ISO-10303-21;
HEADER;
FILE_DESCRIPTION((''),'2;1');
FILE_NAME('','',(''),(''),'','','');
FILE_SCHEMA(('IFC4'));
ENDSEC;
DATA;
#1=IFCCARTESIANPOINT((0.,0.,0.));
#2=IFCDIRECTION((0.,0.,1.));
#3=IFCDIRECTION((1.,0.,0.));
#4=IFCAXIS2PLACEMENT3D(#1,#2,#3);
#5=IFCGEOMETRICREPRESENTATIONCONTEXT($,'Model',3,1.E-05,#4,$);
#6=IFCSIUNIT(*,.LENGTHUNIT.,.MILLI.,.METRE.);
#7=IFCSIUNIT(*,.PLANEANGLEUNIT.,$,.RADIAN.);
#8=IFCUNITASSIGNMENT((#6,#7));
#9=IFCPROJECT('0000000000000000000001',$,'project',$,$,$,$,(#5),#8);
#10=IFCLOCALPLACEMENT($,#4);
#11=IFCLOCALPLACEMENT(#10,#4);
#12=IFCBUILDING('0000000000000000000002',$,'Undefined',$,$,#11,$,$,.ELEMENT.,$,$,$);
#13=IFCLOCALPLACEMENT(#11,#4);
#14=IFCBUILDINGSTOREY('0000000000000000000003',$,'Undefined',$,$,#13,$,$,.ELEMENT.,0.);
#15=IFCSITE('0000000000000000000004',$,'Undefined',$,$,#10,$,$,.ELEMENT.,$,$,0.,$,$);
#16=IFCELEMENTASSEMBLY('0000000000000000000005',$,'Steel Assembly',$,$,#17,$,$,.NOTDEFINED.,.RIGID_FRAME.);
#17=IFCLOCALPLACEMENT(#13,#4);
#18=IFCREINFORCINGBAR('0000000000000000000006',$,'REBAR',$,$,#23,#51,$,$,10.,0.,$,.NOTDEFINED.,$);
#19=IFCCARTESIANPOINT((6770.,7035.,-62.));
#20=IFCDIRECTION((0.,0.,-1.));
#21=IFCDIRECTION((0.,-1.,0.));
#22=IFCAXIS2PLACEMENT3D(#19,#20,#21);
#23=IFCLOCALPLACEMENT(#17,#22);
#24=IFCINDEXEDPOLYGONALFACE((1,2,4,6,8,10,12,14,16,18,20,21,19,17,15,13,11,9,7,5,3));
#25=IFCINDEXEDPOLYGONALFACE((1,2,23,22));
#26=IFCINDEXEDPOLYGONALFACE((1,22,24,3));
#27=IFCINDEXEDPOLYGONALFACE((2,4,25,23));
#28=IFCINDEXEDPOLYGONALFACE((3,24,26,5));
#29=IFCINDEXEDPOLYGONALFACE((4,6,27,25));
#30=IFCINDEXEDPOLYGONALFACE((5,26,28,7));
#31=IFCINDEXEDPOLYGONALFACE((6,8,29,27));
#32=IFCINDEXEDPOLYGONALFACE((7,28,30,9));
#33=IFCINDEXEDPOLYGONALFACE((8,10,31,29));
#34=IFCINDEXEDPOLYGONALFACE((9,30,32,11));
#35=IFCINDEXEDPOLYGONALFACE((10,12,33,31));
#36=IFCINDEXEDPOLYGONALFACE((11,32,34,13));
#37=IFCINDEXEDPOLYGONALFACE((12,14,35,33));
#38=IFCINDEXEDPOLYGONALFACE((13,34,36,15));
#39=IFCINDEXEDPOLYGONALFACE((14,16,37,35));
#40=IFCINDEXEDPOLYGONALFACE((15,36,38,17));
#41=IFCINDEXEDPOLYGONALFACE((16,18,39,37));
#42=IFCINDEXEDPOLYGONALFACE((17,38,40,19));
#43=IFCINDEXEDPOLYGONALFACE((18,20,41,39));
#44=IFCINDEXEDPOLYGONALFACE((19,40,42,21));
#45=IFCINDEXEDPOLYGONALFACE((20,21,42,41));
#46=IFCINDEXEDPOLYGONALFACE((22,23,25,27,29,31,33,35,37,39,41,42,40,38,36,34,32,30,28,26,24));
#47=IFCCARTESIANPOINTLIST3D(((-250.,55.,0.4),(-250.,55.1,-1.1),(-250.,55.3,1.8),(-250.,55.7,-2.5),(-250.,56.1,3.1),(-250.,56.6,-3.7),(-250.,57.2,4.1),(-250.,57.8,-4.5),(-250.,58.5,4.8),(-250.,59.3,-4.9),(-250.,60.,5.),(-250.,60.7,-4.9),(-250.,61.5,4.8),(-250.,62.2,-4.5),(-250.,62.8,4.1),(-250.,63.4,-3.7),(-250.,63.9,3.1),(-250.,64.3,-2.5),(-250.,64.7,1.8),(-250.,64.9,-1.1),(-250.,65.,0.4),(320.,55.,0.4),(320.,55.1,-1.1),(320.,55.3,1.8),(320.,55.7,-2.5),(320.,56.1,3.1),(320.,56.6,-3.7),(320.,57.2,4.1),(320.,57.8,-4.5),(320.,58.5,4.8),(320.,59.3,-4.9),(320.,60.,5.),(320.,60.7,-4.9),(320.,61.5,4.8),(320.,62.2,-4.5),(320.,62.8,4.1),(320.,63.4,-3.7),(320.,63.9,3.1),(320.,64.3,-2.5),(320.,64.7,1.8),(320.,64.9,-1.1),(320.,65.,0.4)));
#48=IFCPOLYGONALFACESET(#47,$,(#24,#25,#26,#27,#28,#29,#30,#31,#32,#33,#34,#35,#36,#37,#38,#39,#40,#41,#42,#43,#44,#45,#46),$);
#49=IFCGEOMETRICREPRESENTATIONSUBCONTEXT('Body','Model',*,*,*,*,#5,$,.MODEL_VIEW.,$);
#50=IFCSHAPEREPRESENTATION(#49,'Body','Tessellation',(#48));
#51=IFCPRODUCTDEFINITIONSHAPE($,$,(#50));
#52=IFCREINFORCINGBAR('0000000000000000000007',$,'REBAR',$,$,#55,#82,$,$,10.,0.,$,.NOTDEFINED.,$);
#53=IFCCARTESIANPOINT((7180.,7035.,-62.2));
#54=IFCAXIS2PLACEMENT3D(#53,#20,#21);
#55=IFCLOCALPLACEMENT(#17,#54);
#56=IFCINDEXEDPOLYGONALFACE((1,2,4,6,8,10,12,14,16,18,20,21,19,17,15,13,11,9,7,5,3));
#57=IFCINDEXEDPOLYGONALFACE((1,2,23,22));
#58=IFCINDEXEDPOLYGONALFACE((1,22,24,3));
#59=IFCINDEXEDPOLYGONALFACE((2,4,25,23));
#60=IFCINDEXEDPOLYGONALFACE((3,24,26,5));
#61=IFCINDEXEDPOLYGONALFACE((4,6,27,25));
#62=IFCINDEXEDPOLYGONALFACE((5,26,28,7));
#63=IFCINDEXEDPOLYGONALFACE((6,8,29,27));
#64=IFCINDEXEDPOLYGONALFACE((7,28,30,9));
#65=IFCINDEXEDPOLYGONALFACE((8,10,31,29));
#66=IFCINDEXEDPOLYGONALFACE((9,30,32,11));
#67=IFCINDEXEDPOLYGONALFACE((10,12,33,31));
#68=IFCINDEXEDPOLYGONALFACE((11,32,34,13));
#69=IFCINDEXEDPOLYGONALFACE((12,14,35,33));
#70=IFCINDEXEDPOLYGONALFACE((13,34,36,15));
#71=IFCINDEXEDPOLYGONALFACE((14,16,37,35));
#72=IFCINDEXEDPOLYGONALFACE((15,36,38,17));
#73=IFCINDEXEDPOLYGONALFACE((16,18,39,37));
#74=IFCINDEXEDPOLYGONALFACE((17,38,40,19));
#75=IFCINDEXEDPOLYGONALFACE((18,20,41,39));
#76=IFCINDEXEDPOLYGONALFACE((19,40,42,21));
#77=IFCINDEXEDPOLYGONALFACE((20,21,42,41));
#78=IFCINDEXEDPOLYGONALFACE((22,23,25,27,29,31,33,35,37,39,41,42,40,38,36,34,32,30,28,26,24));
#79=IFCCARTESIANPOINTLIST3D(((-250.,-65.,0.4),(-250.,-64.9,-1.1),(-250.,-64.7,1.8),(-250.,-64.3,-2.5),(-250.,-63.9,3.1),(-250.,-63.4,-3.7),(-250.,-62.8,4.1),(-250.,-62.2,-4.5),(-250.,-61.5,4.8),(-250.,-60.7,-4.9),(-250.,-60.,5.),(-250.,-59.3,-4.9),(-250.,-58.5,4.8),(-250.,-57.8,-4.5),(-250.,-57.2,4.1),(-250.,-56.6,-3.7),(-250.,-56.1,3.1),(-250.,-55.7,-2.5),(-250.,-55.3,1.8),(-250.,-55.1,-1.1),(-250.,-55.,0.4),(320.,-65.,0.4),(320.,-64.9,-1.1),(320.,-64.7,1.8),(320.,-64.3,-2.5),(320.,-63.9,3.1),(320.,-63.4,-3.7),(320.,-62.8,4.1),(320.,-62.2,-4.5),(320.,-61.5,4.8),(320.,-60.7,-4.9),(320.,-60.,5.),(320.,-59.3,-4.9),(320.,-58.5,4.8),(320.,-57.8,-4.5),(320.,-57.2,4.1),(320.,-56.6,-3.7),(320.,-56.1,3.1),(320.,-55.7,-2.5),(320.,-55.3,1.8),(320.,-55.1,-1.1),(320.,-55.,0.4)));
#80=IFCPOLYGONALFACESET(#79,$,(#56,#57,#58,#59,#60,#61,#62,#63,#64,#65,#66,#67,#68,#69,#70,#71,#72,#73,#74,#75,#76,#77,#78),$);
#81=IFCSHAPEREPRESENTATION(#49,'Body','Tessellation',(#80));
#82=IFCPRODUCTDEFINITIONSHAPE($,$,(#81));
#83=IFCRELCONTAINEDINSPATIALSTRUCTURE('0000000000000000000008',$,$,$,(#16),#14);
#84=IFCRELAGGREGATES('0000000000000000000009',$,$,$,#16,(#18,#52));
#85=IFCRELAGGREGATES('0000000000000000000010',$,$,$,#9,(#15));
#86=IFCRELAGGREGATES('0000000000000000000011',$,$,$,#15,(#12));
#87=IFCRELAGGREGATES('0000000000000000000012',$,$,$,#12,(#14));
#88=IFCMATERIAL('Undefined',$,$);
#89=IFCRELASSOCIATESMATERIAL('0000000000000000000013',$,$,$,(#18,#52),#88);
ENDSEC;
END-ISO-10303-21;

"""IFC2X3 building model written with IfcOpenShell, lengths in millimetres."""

from ifc_helpers import new_model, entity, si_unit, frame, origin_with_axes, place, context, subcontext, project, spatial, source, transform, mapped, material, element, aggregate, save


model = new_model("IFC2X3")

# Units and contexts
model_context = context("Model", 3, precision=1e-05, world=origin_with_axes())
body_context = subcontext(model_context, "Body", "Model", "MODEL_VIEW")
ifc_project = project(units=[si_unit("LENGTHUNIT", "METRE", prefix="MILLI"), si_unit("PLANEANGLEUNIT", "RADIAN")], contexts=[model_context])

# Site, building, storey
site_placement = place(None, origin_with_axes())
site = spatial("IfcSite", under=ifc_project, at=site_placement, Name="Undefined", CompositionType="ELEMENT", RefElevation=0.0)
building_placement = place(site_placement, origin_with_axes())
building = spatial("IfcBuilding", under=site, at=building_placement, Name="Undefined", CompositionType="ELEMENT")
storey_placement = place(building_placement, origin_with_axes())
storey = spatial("IfcBuildingStorey", under=building, at=storey_placement, Name="Undefined", CompositionType="ELEMENT", Elevation=0.0)

# Element assembly
assembly_1_placement = place(storey_placement, origin_with_axes())
assembly_1 = element("IfcElementAssembly", 1, at=assembly_1_placement, inside=storey, Name="Steel Assembly", AssemblyPlace="NOTDEFINED", PredefinedType="RIGID_FRAME")

# Shared definitions
ifc_material_1 = material(Name="Undefined")

# Reinforcing bars
shared_shape_1 = source(origin_with_axes(), body_context, "Body", "AdvancedSweptSolid", [
    entity("IfcSweptDiskSolid", entity("IfcTrimmedCurve", entity("IfcLine", entity("IfcCartesianPoint", [0.0, 0.0, 0.0]), entity("IfcVector", entity("IfcDirection", [1.0, 0.0, 0.0]), 1.0)), [entity("IfcParameterValue", 0.0)], [entity("IfcParameterValue", 570.0)], True, "PARAMETER"), 5.0, None, 0.0, 570.0),
])
reinforcing_bar_1_placement = place(assembly_1_placement, frame((6770.0, 7035.0, -62.0), z_axis=(0.0, 0.0, -1.0), x_axis=(0.0, -1.0, 0.0)))
reinforcing_bar_1 = element("IfcReinforcingBar", 2, at=reinforcing_bar_1_placement, material=ifc_material_1, Name="REBAR", BarRole="NOTDEFINED", CrossSectionArea=0.0, NominalDiameter=10.0, context=body_context, shape_type="MappedRepresentation", body=[
    mapped(shared_shape_1, transform((-250.0, 60.0, 0.0))),
])
shared_shape_2 = source(origin_with_axes(), body_context, "Body", "AdvancedSweptSolid", [
    entity("IfcSweptDiskSolid", entity("IfcTrimmedCurve", entity("IfcLine", entity("IfcCartesianPoint", [0.0, 0.0, 0.0]), entity("IfcVector", entity("IfcDirection", [1.0, 0.0, 0.0]), 1.0)), [entity("IfcParameterValue", 0.0)], [entity("IfcParameterValue", 570.0)], True, "PARAMETER"), 5.0, None, 0.0, 570.0),
])
reinforcing_bar_2_placement = place(assembly_1_placement, frame((7180.0, 7035.0, -62.2), z_axis=(0.0, 0.0, -1.0), x_axis=(0.0, -1.0, 0.0)))
reinforcing_bar_2 = element("IfcReinforcingBar", 3, at=reinforcing_bar_2_placement, material=ifc_material_1, Name="REBAR", BarRole="NOTDEFINED", CrossSectionArea=0.0, NominalDiameter=10.0, context=body_context, shape_type="MappedRepresentation", body=[
    mapped(shared_shape_2, transform((-250.0, -60.0, 0.0))),
])
aggregate(assembly_1, [reinforcing_bar_1, reinforcing_bar_2])

save(model, "model.ifc")
